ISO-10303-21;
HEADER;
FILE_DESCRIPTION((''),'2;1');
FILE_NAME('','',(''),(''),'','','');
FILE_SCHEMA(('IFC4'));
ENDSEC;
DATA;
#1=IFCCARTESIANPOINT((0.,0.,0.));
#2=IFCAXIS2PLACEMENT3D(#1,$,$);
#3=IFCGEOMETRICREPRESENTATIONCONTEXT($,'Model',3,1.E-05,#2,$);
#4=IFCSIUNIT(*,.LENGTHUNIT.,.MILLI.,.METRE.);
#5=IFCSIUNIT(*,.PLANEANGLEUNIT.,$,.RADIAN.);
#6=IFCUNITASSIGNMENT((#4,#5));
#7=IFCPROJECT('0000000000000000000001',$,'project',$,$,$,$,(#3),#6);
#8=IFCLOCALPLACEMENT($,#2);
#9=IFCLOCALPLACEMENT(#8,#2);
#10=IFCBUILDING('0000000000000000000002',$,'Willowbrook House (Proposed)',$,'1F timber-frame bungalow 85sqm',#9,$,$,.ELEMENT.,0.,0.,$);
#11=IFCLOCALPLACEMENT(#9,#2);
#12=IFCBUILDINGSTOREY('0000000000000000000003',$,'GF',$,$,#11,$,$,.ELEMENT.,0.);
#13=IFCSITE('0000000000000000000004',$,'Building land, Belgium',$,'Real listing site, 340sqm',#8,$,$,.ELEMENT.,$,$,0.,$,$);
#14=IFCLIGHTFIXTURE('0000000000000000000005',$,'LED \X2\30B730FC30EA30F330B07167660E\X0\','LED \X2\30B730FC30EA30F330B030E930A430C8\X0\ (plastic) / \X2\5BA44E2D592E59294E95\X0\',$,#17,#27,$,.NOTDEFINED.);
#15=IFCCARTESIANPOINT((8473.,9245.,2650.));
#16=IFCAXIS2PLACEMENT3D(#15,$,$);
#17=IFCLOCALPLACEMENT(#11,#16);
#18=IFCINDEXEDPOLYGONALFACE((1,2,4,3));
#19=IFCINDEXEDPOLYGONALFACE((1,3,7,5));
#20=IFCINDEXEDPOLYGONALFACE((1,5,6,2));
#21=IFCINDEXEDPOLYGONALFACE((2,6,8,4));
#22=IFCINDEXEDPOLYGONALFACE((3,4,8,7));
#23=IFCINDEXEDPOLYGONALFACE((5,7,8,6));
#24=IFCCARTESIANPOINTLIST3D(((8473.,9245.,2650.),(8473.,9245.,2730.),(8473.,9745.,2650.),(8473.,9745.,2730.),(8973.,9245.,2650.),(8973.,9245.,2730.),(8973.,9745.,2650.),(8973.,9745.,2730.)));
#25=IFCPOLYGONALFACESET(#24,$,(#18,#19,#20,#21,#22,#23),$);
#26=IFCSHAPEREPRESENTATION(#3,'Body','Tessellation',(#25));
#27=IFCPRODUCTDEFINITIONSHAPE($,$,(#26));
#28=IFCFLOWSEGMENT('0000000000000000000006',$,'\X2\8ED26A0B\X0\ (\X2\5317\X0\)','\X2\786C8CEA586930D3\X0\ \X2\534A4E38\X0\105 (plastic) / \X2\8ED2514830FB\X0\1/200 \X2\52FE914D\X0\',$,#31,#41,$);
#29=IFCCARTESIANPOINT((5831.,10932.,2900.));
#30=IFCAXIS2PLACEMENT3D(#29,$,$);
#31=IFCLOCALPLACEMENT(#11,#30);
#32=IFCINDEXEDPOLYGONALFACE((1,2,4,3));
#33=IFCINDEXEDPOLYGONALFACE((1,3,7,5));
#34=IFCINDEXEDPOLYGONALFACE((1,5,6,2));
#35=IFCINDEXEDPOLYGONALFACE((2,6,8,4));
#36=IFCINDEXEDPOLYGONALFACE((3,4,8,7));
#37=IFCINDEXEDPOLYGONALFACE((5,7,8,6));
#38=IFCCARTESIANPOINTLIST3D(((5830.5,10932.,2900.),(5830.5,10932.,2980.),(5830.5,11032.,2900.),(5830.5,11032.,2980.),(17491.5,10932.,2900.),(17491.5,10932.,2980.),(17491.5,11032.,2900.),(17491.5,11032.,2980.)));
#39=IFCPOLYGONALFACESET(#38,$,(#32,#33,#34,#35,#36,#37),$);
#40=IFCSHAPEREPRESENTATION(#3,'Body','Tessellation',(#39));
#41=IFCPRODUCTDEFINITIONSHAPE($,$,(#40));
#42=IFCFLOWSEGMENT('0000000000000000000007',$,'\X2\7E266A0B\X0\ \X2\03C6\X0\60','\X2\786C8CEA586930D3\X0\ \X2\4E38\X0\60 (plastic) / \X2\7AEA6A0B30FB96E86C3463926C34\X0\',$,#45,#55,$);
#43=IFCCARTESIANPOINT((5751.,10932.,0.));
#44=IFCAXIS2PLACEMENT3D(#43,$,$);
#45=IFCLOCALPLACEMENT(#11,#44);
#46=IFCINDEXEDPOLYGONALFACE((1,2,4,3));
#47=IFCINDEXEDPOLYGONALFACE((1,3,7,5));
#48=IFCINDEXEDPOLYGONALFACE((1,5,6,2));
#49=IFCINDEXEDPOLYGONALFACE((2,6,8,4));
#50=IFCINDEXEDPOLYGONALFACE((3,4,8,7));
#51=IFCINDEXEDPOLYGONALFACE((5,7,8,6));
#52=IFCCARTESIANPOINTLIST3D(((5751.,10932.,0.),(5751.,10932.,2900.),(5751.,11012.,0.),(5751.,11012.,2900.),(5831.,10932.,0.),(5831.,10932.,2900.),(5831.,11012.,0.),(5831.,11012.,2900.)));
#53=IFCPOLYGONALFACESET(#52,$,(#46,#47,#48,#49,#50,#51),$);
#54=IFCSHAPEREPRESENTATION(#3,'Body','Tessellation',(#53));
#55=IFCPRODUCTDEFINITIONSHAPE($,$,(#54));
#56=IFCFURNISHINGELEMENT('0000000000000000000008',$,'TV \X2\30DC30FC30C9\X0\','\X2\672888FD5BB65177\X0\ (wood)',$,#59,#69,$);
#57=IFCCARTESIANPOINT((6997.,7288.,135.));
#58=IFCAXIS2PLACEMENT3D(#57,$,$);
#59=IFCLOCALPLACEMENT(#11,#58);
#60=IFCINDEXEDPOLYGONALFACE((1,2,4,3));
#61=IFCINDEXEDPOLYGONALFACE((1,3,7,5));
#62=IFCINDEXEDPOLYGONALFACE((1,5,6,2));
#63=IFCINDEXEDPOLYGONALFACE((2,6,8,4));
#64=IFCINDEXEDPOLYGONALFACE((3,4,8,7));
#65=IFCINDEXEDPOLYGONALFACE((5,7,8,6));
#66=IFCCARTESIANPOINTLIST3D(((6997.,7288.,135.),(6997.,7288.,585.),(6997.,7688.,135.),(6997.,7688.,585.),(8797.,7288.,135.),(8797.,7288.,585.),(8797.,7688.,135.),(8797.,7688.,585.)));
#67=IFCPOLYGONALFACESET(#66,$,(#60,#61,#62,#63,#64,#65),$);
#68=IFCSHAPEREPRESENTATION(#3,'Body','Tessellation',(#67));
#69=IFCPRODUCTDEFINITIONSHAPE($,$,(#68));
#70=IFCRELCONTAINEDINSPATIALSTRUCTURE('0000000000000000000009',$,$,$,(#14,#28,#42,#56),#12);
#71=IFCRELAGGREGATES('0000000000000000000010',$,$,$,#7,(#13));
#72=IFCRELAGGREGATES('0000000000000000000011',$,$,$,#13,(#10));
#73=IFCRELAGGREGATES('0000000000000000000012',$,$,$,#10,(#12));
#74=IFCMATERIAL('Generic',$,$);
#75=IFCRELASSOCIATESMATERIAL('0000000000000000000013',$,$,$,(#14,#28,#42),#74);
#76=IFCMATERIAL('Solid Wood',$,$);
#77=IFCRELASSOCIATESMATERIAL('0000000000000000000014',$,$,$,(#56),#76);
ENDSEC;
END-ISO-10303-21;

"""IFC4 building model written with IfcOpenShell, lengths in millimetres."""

from ifc_helpers import new_model, si_unit, frame, frame_2d, origin, place, context, project, spatial, rectangle, extrude, material, element, save


model = new_model("IFC4")

# Units and contexts
model_context = context("Model", 3, precision=1e-05, world=origin())
ifc_project = project(units=[si_unit("LENGTHUNIT", "METRE", prefix="MILLI"), si_unit("PLANEANGLEUNIT", "RADIAN")], contexts=[model_context])

# Site, building, storey
site_placement = place(None, origin())
site = spatial("IfcSite", under=ifc_project, at=site_placement, Name="Building land, Belgium", ObjectType="Real listing site, 340sqm", CompositionType="ELEMENT", RefElevation=0.0)
building_placement = place(site_placement, origin())
building = spatial("IfcBuilding", under=site, at=building_placement, Name="Willowbrook House (Proposed)", ObjectType="1F timber-frame bungalow 85sqm", CompositionType="ELEMENT", ElevationOfRefHeight=0.0, ElevationOfTerrain=0.0)
storey_placement = place(building_placement, origin())
storey = spatial("IfcBuildingStorey", under=building, at=storey_placement, Name="GF", CompositionType="ELEMENT", Elevation=0.0)

# Shared definitions
ifc_material_1 = material(Name="Solid Wood")

# Shared definitions
ifc_material_2 = material(Name="Generic")

# Light fixture
light_fixture_placement = place(storey_placement, frame((8473.0, 9245.0, 2650.0)))
element("IfcLightFixture", 1, at=light_fixture_placement, inside=storey, material=ifc_material_2, Name="LED シーリング照明", Description="LED シーリングライト (plastic) / 室中央天井", PredefinedType="NOTDEFINED", context=model_context, shape_type="SweptSolid", body=[
    extrude(rectangle(XDim=500.0, YDim=500.0, at=frame_2d((250.0, 250.0))), frame((8473.0, 9245.0, 2650.0)), (0.0, 0.0, 1.0), 80.0),
])

# Flow segments
flow_segment_1_placement = place(storey_placement, frame((5831.0, 10932.0, 2900.0)))
element("IfcFlowSegment", 2, at=flow_segment_1_placement, inside=storey, material=ifc_material_2, Name="軒樋 (北)", Description="硬質塩ビ 半丸105 (plastic) / 軒先・1/200 勾配", context=model_context, shape_type="SweptSolid", body=[
    extrude(rectangle(XDim=11661.0, YDim=100.0, at=frame_2d((5830.0, 50.0))), frame((5831.0, 10932.0, 2900.0)), (0.0, 0.0, 1.0), 80.0),
])
flow_segment_2_placement = place(storey_placement, frame((5751.0, 10932.0, 0.0)))
element("IfcFlowSegment", 3, at=flow_segment_2_placement, inside=storey, material=ifc_material_2, Name="縦樋 φ60", Description="硬質塩ビ 丸60 (plastic) / 竪樋・雨水排水", context=model_context, shape_type="SweptSolid", body=[
    extrude(rectangle(XDim=80.0, YDim=80.0, at=frame_2d((40.0, 40.0))), frame((5751.0, 10932.0, 0.0)), (0.0, 0.0, 1.0), 2900.0),
])

# Furnishing element
furnishing_placement = place(storey_placement, frame((6997.0, 7288.0, 135.0)))
element("IfcFurnishingElement", 4, at=furnishing_placement, inside=storey, material=ifc_material_1, Name="TV ボード", Description="木製家具 (wood)", context=model_context, shape_type="SweptSolid", body=[
    extrude(rectangle(XDim=1800.0, YDim=400.0, at=frame_2d((900.0, 200.0))), frame((6997.0, 7288.0, 135.0)), (0.0, 0.0, 1.0), 450.0),
])

save(model, "model.ifc")
